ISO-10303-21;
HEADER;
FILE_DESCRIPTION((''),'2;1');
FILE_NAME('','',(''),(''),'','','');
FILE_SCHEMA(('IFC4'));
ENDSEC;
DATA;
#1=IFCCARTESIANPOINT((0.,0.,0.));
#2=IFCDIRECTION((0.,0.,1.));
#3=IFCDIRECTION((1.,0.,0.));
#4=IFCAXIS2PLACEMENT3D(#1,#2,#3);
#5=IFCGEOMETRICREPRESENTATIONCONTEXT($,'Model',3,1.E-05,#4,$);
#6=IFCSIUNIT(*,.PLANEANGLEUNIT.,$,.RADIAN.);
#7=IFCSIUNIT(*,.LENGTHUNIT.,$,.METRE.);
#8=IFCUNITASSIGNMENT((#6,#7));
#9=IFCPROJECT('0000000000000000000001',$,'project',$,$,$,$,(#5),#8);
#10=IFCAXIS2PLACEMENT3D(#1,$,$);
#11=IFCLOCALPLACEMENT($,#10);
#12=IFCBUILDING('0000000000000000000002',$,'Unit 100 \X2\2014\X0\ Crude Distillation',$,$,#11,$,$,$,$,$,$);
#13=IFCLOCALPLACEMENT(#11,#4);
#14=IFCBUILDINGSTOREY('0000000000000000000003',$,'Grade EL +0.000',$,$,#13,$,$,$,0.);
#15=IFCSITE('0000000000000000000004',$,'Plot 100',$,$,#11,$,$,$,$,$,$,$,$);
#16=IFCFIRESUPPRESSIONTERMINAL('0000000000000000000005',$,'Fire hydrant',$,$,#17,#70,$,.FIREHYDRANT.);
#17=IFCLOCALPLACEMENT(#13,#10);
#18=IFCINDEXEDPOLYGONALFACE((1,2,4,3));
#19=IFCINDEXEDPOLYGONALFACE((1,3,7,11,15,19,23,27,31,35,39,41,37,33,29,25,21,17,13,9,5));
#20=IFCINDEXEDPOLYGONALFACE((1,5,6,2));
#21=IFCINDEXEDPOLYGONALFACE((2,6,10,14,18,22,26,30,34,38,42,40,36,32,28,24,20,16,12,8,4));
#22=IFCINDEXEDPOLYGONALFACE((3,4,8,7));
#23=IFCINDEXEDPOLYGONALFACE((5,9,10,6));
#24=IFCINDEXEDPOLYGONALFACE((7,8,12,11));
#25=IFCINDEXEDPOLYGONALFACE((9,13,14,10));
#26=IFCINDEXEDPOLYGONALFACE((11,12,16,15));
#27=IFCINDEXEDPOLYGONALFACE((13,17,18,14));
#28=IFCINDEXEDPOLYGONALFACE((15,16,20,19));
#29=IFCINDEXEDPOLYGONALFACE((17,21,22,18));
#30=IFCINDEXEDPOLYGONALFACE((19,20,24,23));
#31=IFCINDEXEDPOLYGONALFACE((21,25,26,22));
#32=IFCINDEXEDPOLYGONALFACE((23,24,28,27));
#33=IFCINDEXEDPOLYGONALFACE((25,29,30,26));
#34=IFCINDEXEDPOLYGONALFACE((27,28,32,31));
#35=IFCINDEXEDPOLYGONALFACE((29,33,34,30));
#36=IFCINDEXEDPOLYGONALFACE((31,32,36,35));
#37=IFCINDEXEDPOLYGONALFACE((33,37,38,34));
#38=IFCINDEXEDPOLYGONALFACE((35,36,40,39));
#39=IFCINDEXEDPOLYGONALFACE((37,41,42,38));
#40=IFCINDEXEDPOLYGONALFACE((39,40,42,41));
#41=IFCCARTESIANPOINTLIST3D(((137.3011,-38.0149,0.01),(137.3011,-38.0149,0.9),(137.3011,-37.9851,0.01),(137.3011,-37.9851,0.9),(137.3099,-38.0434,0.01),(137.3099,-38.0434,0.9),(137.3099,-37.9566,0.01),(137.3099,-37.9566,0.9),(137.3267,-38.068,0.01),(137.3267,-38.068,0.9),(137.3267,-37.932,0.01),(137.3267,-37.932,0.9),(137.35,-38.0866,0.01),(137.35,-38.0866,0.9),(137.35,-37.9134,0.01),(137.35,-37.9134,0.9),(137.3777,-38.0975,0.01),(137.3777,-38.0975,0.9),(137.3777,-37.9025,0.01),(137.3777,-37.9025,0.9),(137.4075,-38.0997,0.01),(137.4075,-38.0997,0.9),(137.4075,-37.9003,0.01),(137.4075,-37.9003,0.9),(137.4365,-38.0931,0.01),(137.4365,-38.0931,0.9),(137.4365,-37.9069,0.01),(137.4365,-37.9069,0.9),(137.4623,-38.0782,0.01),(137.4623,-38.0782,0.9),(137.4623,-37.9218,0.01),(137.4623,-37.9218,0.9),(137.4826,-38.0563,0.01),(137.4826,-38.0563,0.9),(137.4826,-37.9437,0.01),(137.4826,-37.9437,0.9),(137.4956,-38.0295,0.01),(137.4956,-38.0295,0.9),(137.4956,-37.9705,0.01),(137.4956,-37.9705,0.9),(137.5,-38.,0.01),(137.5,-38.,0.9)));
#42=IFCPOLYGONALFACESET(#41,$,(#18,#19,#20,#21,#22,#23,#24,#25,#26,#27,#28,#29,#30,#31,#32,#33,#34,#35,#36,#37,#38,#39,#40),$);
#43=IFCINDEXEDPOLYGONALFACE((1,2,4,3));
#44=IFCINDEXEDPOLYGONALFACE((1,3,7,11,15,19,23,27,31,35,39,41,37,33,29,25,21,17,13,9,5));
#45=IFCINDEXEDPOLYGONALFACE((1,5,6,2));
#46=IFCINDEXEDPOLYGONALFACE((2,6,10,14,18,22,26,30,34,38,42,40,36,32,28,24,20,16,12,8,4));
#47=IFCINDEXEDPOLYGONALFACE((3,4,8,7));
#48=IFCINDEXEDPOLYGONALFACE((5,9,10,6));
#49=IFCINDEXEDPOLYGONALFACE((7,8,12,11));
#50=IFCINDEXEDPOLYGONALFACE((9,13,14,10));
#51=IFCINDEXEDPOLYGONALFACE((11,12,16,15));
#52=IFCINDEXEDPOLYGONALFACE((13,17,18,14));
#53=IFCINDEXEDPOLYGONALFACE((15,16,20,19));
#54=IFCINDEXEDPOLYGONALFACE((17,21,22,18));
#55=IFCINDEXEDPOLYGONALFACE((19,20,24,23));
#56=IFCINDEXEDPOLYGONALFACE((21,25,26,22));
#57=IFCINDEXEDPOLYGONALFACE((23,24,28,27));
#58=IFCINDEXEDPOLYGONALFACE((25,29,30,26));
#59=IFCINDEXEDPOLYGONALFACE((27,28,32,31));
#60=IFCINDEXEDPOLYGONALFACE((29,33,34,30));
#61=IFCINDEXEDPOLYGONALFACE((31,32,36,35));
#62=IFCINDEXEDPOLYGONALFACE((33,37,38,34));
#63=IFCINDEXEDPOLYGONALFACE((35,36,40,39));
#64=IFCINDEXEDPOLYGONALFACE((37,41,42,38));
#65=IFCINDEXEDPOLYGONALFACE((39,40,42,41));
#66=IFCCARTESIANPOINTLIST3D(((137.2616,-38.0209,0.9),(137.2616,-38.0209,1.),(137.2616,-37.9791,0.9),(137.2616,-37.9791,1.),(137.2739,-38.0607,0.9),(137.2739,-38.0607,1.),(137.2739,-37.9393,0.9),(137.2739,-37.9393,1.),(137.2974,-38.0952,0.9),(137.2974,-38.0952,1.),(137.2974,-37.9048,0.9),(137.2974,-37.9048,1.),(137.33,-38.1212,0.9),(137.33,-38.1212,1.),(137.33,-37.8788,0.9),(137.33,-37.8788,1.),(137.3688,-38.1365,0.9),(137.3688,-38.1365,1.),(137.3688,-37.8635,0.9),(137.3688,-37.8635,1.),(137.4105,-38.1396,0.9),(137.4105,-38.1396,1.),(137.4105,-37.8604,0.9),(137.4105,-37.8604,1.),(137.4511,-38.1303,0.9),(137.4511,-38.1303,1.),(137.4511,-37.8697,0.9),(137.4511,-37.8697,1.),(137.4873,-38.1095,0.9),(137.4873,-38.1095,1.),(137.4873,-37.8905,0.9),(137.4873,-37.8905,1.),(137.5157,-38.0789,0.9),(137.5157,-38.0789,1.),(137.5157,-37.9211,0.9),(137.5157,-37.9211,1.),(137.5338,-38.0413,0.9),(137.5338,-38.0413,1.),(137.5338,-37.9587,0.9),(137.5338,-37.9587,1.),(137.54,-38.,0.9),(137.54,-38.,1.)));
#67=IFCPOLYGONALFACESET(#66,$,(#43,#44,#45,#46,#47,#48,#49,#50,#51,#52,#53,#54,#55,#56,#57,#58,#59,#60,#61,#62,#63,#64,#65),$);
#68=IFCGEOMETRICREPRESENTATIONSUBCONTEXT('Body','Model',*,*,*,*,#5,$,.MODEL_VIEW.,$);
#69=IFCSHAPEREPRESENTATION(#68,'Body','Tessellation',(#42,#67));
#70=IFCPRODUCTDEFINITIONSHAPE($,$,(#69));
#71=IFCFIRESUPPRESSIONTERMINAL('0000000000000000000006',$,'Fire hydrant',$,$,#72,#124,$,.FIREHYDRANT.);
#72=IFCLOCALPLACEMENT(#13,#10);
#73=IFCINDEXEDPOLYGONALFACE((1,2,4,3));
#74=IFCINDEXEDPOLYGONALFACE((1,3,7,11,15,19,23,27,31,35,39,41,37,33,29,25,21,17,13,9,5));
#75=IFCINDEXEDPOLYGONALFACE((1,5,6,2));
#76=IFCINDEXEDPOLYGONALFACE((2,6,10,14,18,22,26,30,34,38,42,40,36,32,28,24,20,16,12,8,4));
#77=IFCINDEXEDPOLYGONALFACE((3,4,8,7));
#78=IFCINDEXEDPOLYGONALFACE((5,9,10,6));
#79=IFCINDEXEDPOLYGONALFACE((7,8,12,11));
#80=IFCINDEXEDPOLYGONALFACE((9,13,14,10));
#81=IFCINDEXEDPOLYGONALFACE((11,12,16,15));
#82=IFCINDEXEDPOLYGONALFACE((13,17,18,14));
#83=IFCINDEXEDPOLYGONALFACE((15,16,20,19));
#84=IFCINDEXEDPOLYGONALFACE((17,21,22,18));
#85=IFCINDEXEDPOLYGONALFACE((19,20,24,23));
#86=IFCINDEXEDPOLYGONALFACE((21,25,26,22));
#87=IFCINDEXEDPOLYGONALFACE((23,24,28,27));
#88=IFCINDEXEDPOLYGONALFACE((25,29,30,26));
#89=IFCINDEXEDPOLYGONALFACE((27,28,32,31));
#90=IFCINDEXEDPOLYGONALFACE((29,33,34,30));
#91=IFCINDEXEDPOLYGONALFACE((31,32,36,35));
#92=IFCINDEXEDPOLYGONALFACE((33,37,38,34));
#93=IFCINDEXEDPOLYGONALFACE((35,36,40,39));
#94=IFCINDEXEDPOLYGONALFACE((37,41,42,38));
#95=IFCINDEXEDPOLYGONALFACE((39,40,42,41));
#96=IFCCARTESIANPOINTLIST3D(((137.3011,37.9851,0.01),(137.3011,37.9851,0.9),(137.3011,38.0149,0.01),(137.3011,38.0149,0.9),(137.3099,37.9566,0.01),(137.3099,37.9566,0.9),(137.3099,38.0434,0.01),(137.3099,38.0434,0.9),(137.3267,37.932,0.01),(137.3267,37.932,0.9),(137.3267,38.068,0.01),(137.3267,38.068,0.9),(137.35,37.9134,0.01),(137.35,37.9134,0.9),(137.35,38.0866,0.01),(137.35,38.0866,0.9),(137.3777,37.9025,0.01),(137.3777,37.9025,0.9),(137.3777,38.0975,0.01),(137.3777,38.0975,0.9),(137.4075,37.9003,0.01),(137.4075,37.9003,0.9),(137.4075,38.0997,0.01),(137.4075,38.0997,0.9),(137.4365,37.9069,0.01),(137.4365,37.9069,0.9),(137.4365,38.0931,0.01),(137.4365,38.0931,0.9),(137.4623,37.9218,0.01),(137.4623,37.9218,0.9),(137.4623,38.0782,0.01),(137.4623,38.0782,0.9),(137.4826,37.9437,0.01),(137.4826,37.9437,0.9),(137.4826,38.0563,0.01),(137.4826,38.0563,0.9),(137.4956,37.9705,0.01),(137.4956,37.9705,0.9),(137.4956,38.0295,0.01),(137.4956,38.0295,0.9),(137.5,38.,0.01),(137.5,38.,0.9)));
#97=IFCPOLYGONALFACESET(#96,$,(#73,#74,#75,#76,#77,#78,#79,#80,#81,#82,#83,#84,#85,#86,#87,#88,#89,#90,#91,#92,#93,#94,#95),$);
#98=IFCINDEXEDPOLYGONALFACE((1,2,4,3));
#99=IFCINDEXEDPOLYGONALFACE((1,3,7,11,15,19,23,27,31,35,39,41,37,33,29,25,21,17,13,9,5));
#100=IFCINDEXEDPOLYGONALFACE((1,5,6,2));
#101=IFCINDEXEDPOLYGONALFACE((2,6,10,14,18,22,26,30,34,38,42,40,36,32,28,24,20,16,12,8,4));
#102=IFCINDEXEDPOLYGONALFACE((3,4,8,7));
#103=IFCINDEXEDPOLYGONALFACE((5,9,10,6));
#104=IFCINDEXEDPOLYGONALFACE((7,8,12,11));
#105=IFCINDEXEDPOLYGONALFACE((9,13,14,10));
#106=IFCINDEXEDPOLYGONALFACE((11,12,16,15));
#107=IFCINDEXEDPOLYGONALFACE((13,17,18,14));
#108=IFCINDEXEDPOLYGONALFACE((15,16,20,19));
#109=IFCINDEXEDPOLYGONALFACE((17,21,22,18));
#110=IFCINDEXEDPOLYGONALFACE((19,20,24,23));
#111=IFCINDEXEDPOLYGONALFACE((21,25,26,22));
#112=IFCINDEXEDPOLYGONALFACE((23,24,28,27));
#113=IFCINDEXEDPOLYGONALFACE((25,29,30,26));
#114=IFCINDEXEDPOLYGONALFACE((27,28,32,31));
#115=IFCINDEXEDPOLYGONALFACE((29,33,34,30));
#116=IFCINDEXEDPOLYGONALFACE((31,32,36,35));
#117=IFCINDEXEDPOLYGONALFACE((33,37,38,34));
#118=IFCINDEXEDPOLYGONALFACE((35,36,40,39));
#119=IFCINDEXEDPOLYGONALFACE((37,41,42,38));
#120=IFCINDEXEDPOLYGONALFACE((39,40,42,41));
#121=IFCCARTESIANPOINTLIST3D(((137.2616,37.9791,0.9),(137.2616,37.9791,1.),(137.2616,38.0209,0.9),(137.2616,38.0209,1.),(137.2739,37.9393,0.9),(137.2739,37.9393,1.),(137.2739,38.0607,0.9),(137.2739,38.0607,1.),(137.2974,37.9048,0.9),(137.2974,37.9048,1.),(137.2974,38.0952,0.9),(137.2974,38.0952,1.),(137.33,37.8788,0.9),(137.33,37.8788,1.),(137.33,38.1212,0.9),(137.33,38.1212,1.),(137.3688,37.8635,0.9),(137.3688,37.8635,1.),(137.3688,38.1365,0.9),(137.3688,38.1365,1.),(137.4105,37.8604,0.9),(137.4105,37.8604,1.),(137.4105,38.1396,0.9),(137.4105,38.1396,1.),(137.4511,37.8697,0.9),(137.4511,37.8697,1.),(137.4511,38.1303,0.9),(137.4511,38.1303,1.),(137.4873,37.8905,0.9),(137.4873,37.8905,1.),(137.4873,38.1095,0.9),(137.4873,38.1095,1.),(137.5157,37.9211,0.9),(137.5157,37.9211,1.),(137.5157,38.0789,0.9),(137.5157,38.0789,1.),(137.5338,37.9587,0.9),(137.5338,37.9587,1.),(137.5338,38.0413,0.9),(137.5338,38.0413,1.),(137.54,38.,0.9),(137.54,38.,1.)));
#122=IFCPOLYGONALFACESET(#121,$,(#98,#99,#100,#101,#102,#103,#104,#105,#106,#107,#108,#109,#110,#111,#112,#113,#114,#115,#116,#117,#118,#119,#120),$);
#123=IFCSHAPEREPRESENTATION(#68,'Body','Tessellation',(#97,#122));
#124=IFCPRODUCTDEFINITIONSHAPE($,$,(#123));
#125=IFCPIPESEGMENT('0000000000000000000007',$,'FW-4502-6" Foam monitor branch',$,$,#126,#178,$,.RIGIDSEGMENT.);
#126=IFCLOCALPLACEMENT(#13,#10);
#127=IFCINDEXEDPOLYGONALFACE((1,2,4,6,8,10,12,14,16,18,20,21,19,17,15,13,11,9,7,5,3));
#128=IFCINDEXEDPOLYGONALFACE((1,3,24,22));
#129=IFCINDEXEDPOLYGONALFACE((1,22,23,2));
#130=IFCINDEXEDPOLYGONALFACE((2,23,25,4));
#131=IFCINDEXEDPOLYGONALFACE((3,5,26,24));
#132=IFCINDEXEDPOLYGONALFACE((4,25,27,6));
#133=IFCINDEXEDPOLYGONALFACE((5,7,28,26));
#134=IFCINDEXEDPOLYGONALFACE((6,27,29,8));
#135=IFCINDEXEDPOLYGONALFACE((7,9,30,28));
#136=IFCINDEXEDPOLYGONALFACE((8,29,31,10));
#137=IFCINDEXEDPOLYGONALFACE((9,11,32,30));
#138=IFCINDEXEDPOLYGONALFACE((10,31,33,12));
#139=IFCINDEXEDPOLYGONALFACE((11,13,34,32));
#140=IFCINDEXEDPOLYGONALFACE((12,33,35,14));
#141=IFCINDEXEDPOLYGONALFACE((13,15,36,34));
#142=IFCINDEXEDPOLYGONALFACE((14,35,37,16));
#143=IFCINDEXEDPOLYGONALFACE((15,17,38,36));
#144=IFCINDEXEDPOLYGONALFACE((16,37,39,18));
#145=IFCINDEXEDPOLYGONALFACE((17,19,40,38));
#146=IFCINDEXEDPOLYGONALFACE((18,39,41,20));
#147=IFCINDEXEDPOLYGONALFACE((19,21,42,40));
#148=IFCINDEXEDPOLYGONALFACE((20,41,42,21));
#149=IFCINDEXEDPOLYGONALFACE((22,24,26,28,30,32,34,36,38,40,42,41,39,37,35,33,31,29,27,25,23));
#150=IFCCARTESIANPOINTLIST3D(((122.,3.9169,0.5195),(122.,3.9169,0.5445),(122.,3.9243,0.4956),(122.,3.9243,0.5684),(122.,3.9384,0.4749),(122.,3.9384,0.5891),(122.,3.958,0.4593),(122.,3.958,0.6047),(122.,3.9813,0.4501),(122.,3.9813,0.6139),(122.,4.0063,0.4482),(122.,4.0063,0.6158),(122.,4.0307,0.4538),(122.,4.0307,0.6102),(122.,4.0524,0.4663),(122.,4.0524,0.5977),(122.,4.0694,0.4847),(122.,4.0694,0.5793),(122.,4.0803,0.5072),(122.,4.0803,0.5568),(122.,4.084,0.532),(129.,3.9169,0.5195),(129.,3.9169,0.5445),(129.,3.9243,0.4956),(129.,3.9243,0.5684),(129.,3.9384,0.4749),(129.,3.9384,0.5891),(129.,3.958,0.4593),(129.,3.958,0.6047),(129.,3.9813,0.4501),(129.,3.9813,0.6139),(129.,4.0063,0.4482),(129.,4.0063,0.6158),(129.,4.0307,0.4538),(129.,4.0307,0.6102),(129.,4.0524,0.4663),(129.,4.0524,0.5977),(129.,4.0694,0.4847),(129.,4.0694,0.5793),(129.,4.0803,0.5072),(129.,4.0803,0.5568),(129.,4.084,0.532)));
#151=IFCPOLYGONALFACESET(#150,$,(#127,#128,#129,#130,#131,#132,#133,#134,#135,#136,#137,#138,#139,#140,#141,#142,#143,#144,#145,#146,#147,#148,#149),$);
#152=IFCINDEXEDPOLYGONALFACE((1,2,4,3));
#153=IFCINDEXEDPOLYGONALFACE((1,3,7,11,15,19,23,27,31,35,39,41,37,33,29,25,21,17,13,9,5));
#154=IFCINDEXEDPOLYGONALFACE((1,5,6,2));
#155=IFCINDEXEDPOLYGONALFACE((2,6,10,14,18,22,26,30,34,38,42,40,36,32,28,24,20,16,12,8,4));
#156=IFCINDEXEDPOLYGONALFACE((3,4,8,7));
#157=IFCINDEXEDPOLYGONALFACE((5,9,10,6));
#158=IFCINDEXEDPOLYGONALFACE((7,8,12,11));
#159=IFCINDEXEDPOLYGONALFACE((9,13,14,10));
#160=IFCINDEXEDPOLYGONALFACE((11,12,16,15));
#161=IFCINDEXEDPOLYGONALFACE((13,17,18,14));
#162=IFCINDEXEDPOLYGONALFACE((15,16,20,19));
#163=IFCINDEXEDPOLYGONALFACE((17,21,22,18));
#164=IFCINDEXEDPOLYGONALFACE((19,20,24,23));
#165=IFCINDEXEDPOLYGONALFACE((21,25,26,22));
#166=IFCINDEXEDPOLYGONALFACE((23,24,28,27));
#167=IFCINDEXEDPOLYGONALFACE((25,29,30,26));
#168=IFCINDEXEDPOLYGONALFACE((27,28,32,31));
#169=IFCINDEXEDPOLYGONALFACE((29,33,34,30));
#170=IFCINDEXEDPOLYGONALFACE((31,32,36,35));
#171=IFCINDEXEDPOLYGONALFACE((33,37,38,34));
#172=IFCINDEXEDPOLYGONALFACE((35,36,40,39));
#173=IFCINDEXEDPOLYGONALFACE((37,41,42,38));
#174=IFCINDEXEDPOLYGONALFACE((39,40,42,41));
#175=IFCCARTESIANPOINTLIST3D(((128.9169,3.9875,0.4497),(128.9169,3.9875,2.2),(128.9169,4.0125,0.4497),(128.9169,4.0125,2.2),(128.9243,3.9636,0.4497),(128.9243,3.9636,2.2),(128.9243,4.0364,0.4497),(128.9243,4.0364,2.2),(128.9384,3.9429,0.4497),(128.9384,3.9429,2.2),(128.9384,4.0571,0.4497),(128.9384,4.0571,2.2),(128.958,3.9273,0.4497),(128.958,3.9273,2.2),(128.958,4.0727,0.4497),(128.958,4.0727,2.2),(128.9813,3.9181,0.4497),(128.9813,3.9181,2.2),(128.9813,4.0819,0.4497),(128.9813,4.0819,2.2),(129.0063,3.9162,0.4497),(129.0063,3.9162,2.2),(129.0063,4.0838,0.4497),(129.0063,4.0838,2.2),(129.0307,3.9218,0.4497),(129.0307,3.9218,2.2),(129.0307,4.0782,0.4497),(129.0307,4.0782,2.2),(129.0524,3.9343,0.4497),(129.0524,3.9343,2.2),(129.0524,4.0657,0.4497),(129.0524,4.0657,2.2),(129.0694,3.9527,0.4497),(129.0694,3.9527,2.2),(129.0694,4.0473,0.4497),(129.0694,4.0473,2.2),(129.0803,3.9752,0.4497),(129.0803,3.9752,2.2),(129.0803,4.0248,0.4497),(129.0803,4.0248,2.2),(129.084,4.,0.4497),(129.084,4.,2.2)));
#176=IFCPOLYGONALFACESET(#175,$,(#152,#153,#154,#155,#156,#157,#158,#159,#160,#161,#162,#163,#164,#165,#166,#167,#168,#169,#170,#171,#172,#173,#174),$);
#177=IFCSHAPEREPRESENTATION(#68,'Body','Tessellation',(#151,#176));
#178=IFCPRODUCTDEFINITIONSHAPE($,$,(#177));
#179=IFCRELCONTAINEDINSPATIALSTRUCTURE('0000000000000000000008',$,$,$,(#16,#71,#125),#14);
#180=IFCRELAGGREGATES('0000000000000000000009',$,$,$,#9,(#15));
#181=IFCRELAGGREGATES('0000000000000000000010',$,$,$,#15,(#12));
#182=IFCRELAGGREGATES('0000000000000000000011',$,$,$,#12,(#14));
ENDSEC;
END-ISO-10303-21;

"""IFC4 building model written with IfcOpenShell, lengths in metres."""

from ifc_helpers import new_model, si_unit, frame, origin, origin_with_axes, origin_2d, place, context, subcontext, project, spatial, circle, extrude, element, save


model = new_model("IFC4")

# Units and contexts
model_context = context("Model", 3, precision=1e-05, world=origin_with_axes())
body_context = subcontext(model_context, "Body", "Model", "MODEL_VIEW")
ifc_project = project(units=[si_unit("PLANEANGLEUNIT", "RADIAN"), si_unit("LENGTHUNIT", "METRE")], contexts=[model_context])

# Site, building, storey
placement = place(None, origin())
site = spatial("IfcSite", under=ifc_project, at=placement, Name="Plot 100")
building = spatial("IfcBuilding", under=site, at=placement, Name="Unit 100 — Crude Distillation")
storey_placement = place(placement, origin_with_axes())
storey = spatial("IfcBuildingStorey", under=building, at=storey_placement, Name="Grade EL +0.000", Elevation=0.0)

# Fire suppression terminals
fire_suppression_terminal_1_placement = place(storey_placement, origin_with_axes())
element("IfcFireSuppressionTerminal", 1, at=fire_suppression_terminal_1_placement, inside=storey, Name="Fire hydrant", PredefinedType="FIREHYDRANT", context=body_context, shape_type="SweptSolid", body=[
    extrude(circle(Radius=0.1, at=origin_2d()), frame((137.4, -38.0, 0.01), z_axis=(0.0, 0.0, 1.0), x_axis=(1.0, 0.0, 0.0)), (0.0, 0.0, 1.0), 0.89),
    extrude(circle(Radius=0.14, at=origin_2d()), frame((137.4, -38.0, 0.9), z_axis=(0.0, 0.0, 1.0), x_axis=(1.0, 0.0, 0.0)), (0.0, 0.0, 1.0), 0.1),
])
fire_suppression_terminal_2_placement = place(storey_placement, origin_with_axes())
element("IfcFireSuppressionTerminal", 2, at=fire_suppression_terminal_2_placement, inside=storey, Name="Fire hydrant", PredefinedType="FIREHYDRANT", context=body_context, shape_type="SweptSolid", body=[
    extrude(circle(Radius=0.1, at=origin_2d()), frame((137.4, 38.0, 0.01), z_axis=(0.0, 0.0, 1.0), x_axis=(1.0, 0.0, 0.0)), (0.0, 0.0, 1.0), 0.89),
    extrude(circle(Radius=0.14, at=origin_2d()), frame((137.4, 38.0, 0.9), z_axis=(0.0, 0.0, 1.0), x_axis=(1.0, 0.0, 0.0)), (0.0, 0.0, 1.0), 0.1),
])

# Pipe segment
pipe_segment_1_placement = place(storey_placement, origin_with_axes())
element("IfcPipeSegment", 3, at=pipe_segment_1_placement, inside=storey, Name="FW-4502-6\" Foam monitor branch", PredefinedType="RIGIDSEGMENT", context=body_context, shape_type="SweptSolid", body=[
    extrude(circle(Radius=0.084, at=origin_2d()), frame((122.0, 4.0, 0.532), z_axis=(1.0, 0.0, 0.0), x_axis=(0.0, 1.0, 0.0)), (0.0, 0.0, 1.0), 7.0),
    extrude(circle(Radius=0.084, at=origin_2d()), frame((129.0, 4.0, 0.4497), z_axis=(0.0, 0.0, 1.0), x_axis=(1.0, 0.0, 0.0)), (0.0, 0.0, 1.0), 1.7503),
])

save(model, "model.ifc")
